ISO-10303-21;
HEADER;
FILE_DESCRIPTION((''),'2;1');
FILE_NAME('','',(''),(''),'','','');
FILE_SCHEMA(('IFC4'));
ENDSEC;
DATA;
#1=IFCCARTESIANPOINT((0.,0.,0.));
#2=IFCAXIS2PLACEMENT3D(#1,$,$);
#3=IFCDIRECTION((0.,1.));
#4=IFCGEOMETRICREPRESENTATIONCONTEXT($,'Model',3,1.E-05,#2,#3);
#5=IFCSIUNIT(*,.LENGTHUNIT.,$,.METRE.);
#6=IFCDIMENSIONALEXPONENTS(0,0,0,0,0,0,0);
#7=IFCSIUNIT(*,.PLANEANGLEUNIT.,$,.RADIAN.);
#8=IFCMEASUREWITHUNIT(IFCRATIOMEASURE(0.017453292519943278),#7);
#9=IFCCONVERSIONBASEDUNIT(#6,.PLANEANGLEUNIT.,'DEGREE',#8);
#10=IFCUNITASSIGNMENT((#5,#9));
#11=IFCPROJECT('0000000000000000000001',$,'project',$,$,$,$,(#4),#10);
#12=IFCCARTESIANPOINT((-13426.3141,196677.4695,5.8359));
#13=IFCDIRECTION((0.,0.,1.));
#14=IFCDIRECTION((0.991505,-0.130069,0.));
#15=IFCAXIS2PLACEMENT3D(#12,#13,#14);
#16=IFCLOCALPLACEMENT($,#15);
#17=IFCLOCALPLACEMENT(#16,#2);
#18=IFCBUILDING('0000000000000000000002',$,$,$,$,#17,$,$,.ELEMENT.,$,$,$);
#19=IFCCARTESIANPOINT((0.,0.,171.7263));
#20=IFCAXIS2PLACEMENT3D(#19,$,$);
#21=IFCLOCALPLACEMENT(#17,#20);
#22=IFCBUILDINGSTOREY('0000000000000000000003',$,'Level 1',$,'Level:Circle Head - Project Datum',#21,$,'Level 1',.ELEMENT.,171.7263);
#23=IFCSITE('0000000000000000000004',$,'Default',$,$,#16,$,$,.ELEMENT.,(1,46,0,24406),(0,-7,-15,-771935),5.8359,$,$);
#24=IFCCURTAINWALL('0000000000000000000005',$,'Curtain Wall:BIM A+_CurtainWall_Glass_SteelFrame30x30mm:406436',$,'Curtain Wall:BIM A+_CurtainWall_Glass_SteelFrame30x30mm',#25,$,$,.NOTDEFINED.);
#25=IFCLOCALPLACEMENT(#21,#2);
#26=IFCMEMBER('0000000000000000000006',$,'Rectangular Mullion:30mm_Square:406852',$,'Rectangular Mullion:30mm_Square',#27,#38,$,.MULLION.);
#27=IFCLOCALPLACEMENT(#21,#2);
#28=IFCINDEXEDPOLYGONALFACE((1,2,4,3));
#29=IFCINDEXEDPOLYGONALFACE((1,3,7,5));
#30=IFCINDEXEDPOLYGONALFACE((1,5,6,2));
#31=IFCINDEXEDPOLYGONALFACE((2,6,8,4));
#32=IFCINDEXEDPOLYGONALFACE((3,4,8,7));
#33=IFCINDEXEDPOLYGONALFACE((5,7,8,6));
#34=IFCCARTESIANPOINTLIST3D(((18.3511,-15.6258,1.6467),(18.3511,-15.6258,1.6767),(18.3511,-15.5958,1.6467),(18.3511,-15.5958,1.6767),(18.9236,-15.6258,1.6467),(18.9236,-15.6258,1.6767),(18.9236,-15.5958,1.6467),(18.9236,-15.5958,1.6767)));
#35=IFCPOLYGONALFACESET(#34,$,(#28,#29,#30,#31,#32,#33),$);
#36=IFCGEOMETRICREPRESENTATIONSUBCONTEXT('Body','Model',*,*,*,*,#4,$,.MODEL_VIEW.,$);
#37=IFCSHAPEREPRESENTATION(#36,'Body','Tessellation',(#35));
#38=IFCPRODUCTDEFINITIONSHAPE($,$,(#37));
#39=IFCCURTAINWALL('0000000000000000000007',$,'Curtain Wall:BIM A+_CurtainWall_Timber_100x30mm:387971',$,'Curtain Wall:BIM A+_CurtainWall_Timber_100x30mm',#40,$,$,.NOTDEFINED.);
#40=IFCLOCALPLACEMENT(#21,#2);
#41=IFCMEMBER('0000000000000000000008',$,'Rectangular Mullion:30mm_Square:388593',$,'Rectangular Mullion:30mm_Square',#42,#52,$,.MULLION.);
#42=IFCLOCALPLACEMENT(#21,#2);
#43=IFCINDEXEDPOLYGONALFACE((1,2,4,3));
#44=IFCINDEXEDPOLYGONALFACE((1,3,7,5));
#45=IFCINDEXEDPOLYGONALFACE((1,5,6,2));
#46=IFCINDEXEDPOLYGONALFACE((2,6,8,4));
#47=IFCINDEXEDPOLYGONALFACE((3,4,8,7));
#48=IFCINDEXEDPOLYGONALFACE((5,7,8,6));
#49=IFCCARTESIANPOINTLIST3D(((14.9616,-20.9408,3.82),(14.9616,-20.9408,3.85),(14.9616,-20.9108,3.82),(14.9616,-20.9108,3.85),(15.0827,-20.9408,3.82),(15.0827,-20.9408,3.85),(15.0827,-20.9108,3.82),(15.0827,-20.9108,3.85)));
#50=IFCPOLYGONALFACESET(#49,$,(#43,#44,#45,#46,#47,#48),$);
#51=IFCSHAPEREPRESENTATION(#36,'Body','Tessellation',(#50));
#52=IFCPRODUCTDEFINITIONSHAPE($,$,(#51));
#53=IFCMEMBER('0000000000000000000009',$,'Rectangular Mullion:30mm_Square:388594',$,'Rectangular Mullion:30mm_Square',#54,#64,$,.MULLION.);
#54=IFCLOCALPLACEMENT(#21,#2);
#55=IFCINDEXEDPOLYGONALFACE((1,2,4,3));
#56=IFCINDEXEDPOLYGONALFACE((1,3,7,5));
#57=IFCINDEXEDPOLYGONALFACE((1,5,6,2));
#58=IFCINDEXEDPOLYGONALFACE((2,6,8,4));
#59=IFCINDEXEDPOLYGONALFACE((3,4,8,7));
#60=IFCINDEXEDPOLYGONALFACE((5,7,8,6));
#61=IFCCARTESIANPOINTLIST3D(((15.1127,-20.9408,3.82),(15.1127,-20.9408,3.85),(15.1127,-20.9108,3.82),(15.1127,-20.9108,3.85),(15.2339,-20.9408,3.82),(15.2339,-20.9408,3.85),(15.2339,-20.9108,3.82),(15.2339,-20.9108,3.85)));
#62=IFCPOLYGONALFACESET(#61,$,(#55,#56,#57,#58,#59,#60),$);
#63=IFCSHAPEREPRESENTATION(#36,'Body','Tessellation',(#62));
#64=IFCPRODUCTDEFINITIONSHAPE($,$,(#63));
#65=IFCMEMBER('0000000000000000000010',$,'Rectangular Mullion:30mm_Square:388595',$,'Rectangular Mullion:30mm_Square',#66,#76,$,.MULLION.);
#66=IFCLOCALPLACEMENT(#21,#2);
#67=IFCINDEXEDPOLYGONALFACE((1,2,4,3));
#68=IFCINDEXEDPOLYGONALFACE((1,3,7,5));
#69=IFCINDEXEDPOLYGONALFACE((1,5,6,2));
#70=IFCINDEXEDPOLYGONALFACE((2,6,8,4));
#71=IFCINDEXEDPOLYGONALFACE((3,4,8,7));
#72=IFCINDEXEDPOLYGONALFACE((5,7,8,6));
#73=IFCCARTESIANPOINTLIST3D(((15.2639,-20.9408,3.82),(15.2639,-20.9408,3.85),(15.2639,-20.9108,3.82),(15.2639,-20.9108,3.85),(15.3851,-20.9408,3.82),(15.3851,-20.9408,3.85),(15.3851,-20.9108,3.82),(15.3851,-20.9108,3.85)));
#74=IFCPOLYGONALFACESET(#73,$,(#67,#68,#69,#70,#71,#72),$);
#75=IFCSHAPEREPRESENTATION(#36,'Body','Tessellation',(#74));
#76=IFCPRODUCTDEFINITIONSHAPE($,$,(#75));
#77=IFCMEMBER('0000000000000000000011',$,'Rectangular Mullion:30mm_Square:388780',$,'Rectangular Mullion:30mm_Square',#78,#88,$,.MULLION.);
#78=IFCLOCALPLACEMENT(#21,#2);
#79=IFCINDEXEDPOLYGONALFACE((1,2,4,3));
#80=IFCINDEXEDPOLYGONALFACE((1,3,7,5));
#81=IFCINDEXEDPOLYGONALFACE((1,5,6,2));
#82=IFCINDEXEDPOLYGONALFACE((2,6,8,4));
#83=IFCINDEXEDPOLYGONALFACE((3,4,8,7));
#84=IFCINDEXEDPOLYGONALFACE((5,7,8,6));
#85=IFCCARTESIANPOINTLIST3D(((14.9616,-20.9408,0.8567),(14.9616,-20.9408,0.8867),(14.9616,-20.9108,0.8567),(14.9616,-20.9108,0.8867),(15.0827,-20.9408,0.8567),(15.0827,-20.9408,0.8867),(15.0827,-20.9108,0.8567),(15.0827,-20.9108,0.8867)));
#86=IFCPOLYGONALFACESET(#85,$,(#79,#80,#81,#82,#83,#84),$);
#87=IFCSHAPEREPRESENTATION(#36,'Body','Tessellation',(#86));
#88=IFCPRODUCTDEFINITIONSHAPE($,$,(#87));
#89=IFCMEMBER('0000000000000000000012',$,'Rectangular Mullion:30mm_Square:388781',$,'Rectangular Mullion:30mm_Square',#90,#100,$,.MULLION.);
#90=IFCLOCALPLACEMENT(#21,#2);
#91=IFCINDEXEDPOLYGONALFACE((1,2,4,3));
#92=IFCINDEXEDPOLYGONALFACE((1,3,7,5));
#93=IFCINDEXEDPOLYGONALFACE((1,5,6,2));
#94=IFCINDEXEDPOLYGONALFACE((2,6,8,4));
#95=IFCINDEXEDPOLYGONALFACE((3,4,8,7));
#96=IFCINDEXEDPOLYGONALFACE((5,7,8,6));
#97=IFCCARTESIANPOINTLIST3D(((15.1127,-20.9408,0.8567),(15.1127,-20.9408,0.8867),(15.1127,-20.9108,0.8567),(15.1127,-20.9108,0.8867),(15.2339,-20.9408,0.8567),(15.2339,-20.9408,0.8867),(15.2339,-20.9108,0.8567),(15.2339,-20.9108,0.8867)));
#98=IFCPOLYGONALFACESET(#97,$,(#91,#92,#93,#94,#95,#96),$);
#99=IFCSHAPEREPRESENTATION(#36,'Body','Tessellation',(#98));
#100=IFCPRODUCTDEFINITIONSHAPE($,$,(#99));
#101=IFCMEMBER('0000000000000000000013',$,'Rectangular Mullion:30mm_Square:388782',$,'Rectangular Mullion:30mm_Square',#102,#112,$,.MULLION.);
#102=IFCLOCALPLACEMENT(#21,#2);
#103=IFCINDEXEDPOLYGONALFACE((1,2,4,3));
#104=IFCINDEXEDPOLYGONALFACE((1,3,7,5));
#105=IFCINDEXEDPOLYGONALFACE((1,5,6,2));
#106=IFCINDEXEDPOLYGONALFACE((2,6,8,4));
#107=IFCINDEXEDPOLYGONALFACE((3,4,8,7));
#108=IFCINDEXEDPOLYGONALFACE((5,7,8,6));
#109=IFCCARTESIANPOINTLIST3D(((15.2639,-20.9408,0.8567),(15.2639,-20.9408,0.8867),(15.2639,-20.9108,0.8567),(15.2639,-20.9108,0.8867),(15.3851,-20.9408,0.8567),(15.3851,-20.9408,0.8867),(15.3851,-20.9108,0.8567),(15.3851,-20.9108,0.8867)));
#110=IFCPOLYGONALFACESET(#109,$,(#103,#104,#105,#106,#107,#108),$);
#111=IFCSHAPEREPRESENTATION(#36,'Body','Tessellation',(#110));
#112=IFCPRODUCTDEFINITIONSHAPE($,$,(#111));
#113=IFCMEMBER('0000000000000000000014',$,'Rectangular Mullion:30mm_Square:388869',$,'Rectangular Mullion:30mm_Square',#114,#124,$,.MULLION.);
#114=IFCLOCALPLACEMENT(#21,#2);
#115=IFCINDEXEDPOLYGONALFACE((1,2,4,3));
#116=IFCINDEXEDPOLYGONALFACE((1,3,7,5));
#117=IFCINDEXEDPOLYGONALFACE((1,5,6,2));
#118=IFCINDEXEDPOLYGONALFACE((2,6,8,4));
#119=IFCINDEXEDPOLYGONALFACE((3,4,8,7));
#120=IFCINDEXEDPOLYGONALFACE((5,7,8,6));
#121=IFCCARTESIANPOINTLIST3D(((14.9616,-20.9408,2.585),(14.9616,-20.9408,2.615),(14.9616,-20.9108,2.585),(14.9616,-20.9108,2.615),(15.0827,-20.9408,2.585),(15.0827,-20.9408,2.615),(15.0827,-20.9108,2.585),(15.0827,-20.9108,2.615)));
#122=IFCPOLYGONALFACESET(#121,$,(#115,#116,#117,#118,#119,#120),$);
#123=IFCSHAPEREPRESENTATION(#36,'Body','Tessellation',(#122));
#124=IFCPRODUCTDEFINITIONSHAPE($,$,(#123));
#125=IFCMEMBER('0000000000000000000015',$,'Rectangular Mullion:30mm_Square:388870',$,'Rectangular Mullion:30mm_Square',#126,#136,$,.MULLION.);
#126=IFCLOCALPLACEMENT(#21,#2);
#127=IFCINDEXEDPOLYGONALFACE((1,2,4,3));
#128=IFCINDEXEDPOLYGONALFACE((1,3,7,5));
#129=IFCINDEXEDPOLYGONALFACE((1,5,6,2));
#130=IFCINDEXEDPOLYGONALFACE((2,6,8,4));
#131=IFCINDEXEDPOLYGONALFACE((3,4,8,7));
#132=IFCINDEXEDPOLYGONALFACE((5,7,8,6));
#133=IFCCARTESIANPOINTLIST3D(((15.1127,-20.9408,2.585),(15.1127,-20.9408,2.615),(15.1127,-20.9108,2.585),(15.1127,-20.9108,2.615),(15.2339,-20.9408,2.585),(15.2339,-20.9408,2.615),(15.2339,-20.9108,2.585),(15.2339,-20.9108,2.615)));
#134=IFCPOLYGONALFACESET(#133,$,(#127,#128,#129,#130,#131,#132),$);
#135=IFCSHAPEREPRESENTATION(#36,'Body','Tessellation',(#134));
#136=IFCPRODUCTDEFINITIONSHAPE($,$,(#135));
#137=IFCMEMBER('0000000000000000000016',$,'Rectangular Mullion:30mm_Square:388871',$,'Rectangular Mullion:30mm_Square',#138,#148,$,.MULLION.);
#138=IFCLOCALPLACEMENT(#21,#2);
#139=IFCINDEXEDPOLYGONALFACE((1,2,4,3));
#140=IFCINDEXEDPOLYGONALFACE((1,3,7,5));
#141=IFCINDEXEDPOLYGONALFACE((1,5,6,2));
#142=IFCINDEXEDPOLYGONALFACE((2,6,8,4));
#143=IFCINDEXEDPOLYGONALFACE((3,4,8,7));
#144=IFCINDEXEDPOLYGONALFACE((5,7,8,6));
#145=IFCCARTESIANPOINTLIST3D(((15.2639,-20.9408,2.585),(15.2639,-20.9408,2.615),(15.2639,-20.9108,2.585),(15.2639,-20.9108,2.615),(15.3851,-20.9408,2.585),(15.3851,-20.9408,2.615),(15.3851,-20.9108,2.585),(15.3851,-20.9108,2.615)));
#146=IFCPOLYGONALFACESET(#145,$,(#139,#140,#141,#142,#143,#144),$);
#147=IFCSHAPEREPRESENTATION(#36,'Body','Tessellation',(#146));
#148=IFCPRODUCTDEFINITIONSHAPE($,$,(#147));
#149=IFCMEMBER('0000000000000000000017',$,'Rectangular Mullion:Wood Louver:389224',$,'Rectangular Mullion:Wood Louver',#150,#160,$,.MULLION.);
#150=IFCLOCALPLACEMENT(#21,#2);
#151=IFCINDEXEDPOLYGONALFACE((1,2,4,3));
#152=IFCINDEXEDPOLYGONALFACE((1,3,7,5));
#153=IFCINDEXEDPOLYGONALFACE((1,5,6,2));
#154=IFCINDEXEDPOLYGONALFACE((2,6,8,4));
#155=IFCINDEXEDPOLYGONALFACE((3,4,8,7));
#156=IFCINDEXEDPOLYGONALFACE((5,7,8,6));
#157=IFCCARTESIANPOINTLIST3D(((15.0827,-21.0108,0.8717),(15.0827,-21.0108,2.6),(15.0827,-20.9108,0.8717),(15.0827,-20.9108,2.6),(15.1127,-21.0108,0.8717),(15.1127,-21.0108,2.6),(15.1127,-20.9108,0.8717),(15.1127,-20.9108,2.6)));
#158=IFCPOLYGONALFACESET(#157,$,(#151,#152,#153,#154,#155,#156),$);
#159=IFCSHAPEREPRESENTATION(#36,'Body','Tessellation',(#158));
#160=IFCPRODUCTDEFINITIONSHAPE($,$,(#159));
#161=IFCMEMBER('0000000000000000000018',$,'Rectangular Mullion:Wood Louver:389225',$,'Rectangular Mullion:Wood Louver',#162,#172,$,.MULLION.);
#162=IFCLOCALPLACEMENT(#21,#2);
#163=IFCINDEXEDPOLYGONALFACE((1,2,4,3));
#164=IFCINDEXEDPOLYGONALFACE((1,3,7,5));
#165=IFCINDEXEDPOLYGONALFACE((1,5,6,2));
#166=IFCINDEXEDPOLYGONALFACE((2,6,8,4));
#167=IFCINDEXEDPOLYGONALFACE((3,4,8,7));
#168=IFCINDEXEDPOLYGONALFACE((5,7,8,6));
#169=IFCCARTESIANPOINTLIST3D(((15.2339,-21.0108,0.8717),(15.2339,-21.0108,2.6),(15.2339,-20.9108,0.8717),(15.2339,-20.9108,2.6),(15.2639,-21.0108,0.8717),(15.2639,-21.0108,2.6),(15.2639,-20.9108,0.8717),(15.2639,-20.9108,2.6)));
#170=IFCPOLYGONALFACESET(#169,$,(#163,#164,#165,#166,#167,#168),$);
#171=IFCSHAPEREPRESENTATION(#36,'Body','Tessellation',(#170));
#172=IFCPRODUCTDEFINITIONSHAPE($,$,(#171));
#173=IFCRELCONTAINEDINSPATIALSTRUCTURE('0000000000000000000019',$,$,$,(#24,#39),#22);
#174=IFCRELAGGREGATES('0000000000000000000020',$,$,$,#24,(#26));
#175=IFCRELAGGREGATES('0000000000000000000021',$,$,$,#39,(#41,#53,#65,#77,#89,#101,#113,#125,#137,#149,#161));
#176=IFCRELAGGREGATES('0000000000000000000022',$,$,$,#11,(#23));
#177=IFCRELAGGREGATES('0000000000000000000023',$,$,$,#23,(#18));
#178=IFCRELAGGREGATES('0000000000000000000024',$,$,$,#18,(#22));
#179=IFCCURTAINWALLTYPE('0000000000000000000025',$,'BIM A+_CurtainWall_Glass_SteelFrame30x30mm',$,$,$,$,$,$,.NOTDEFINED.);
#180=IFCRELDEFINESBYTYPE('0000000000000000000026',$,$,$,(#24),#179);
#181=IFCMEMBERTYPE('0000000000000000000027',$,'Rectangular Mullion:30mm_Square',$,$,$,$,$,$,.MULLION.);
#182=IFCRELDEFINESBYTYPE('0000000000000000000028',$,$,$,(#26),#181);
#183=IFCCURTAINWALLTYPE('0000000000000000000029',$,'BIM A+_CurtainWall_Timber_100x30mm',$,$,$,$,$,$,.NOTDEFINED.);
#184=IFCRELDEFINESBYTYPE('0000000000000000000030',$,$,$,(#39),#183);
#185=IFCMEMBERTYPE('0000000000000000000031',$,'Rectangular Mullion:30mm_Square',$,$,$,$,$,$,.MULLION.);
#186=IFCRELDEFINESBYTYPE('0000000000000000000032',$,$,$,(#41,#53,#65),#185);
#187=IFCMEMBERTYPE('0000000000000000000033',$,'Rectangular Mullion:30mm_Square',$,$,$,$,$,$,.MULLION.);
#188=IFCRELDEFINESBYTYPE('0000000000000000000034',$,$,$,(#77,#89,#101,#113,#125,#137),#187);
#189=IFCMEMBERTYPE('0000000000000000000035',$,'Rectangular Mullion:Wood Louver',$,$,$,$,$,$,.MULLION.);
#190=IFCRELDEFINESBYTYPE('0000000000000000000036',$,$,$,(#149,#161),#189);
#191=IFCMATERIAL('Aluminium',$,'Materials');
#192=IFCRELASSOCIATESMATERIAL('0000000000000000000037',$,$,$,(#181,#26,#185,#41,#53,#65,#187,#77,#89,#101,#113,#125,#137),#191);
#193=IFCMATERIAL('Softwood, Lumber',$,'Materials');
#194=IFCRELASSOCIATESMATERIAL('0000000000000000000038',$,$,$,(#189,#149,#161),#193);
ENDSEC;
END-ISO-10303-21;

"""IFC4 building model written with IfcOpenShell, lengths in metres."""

from ifc_helpers import new_model, entity, si_unit, converted_unit, direction, frame, origin, place, context, subcontext, project, spatial, indexed_curve, outline, extrude, source, transform, mapped, material, type_object, type_shapes, element, aggregate, save


model = new_model("IFC4")

# Units and contexts
model_context = context("Model", 3, precision=1e-05, world=origin(), true_north=direction((0.0, 1.0)))
body_context = subcontext(model_context, "Body", "Model", "MODEL_VIEW")
ifc_project = project(units=[si_unit("LENGTHUNIT", "METRE"), converted_unit("PLANEANGLEUNIT", "DEGREE", entity("IfcRatioMeasure", 0.017453292519943278), si_unit("PLANEANGLEUNIT", "RADIAN"), dimensions=[0, 0, 0, 0, 0, 0, 0])], contexts=[model_context])

# Site, building, storey
site_placement = place(None, frame((-13426.3141, 196677.4695, 5.8359), z_axis=(0.0, 0.0, 1.0), x_axis=(0.991505, -0.130069, 0.0)))
site = spatial("IfcSite", under=ifc_project, at=site_placement, Name="Default", CompositionType="ELEMENT", RefLatitude=(1, 46, 0, 24406), RefLongitude=(0, -7, -15, -771935), RefElevation=5.8359)
building_placement = place(site_placement, origin())
building = spatial("IfcBuilding", under=site, at=building_placement, CompositionType="ELEMENT")
storey_placement = place(building_placement, frame((0.0, 0.0, 171.7263)))
storey = spatial("IfcBuildingStorey", under=building, at=storey_placement, Name="Level 1", ObjectType="Level:Circle Head - Project Datum", LongName="Level 1", CompositionType="ELEMENT", Elevation=171.7263)

# Shared definitions
curtain_wall_type_1 = type_object("IfcCurtainWallType", Name="BIM A+_CurtainWall_Glass_SteelFrame30x30mm", PredefinedType="NOTDEFINED")
ifc_material_1 = material(Name="Aluminium", Category="Materials")

# Curtain wall
curtain_wall_1_placement = place(storey_placement, frame((0.0, 0.0, -171.7263)))
curtain_wall_1 = element("IfcCurtainWall", 1, at=curtain_wall_1_placement, inside=storey, type_object=curtain_wall_type_1, Name="Curtain Wall:BIM A+_CurtainWall_Glass_SteelFrame30x30mm:406436", ObjectType="Curtain Wall:BIM A+_CurtainWall_Glass_SteelFrame30x30mm", PredefinedType="NOTDEFINED")

# Member
member_type_1 = type_object("IfcMemberType", Name="Rectangular Mullion:30mm_Square", PredefinedType="MULLION", material=ifc_material_1)
shared_shape_1 = source(origin(), body_context, "Body", "SweptSolid", [
    extrude(outline(indexed_curve([(-0.015, -0.015), (0.015, -0.015), (0.015, 0.015), (-0.015, 0.015), (-0.015, -0.015)], self_intersect=False)), frame((0.0, 0.0, -0.5725), z_axis=(0.0, 0.0, 1.0), x_axis=(0.0, -1.0, 0.0)), (0.0, 0.0, 1.0), 0.5725),
])
type_shapes(member_type_1, [shared_shape_1])
member_1_placement = place(curtain_wall_1_placement, frame((18.9236, -15.6108, 173.3879), z_axis=(1.0, 0.0, 0.0), x_axis=(0.0, 0.0, 1.0)))
member_1 = element("IfcMember", 2, at=member_1_placement, type_object=member_type_1, material=ifc_material_1, Name="Rectangular Mullion:30mm_Square:406852", ObjectType="Rectangular Mullion:30mm_Square", PredefinedType="MULLION", context=body_context, shape_type="MappedRepresentation", body=[
    mapped(shared_shape_1, transform((0.0, 0.0, 0.0), scale=1.0)),
])

# Curtain wall, members
curtain_wall_type_2 = type_object("IfcCurtainWallType", Name="BIM A+_CurtainWall_Timber_100x30mm", PredefinedType="NOTDEFINED")
curtain_wall_2_placement = place(storey_placement, frame((0.0, 0.0, -171.7263)))
curtain_wall_2 = element("IfcCurtainWall", 3, at=curtain_wall_2_placement, inside=storey, type_object=curtain_wall_type_2, Name="Curtain Wall:BIM A+_CurtainWall_Timber_100x30mm:387971", ObjectType="Curtain Wall:BIM A+_CurtainWall_Timber_100x30mm", PredefinedType="NOTDEFINED")
member_type_2 = type_object("IfcMemberType", Name="Rectangular Mullion:30mm_Square", PredefinedType="MULLION", material=ifc_material_1)
shared_shape_2 = source(origin(), body_context, "Body", "SweptSolid", [
    extrude(outline(indexed_curve([(-0.015, -0.015), (0.015, -0.015), (0.015, 0.015), (-0.015, 0.015), (-0.015, -0.015)], self_intersect=False)), frame((-0.015, 0.0, -0.1212), z_axis=(0.0, 0.0, 1.0), x_axis=(0.0, -1.0, 0.0)), (0.0, 0.0, 1.0), 0.1212),
])
type_shapes(member_type_2, [shared_shape_2])
member_2_placement = place(curtain_wall_2_placement, frame((15.0827, -20.9258, 175.5763), z_axis=(1.0, 0.0, 0.0), x_axis=(0.0, 0.0, 1.0)))
member_2 = element("IfcMember", 4, at=member_2_placement, type_object=member_type_2, material=ifc_material_1, Name="Rectangular Mullion:30mm_Square:388593", ObjectType="Rectangular Mullion:30mm_Square", PredefinedType="MULLION", context=body_context, shape_type="MappedRepresentation", body=[
    mapped(shared_shape_2, transform((0.0, 0.0, 0.0), scale=1.0)),
])
member_3_placement = place(curtain_wall_2_placement, frame((15.2339, -20.9258, 175.5763), z_axis=(1.0, 0.0, 0.0), x_axis=(0.0, 0.0, 1.0)))
member_3 = element("IfcMember", 5, at=member_3_placement, type_object=member_type_2, material=ifc_material_1, Name="Rectangular Mullion:30mm_Square:388594", ObjectType="Rectangular Mullion:30mm_Square", PredefinedType="MULLION", context=body_context, shape_type="MappedRepresentation", body=[
    mapped(shared_shape_2, transform((0.0, 0.0, 0.0), scale=1.0)),
])
member_4_placement = place(curtain_wall_2_placement, frame((15.3851, -20.9258, 175.5763), z_axis=(1.0, 0.0, 0.0), x_axis=(0.0, 0.0, 1.0)))
member_4 = element("IfcMember", 6, at=member_4_placement, type_object=member_type_2, material=ifc_material_1, Name="Rectangular Mullion:30mm_Square:388595", ObjectType="Rectangular Mullion:30mm_Square", PredefinedType="MULLION", context=body_context, shape_type="MappedRepresentation", body=[
    mapped(shared_shape_2, transform((0.0, 0.0, 0.0), scale=1.0)),
])
member_type_3 = type_object("IfcMemberType", Name="Rectangular Mullion:30mm_Square", PredefinedType="MULLION", material=ifc_material_1)
shared_shape_3 = source(origin(), body_context, "Body", "SweptSolid", [
    extrude(outline(indexed_curve([(-0.015, -0.015), (0.015, -0.015), (0.015, 0.015), (-0.015, 0.015), (-0.015, -0.015)], self_intersect=False)), frame((0.0, 0.0, -0.1212), z_axis=(0.0, 0.0, 1.0), x_axis=(0.0, -1.0, 0.0)), (0.0, 0.0, 1.0), 0.1212),
])
type_shapes(member_type_3, [shared_shape_3])
member_5_placement = place(curtain_wall_2_placement, frame((15.0827, -20.9258, 172.598), z_axis=(1.0, 0.0, 0.0), x_axis=(0.0, 0.0, 1.0)))
member_5 = element("IfcMember", 7, at=member_5_placement, type_object=member_type_3, material=ifc_material_1, Name="Rectangular Mullion:30mm_Square:388780", ObjectType="Rectangular Mullion:30mm_Square", PredefinedType="MULLION", context=body_context, shape_type="MappedRepresentation", body=[
    mapped(shared_shape_3, transform((0.0, 0.0, 0.0), scale=1.0)),
])
member_6_placement = place(curtain_wall_2_placement, frame((15.2339, -20.9258, 172.598), z_axis=(1.0, 0.0, 0.0), x_axis=(0.0, 0.0, 1.0)))
member_6 = element("IfcMember", 8, at=member_6_placement, type_object=member_type_3, material=ifc_material_1, Name="Rectangular Mullion:30mm_Square:388781", ObjectType="Rectangular Mullion:30mm_Square", PredefinedType="MULLION", context=body_context, shape_type="MappedRepresentation", body=[
    mapped(shared_shape_3, transform((0.0, 0.0, 0.0), scale=1.0)),
])
member_7_placement = place(curtain_wall_2_placement, frame((15.3851, -20.9258, 172.598), z_axis=(1.0, 0.0, 0.0), x_axis=(0.0, 0.0, 1.0)))
member_7 = element("IfcMember", 9, at=member_7_placement, type_object=member_type_3, material=ifc_material_1, Name="Rectangular Mullion:30mm_Square:388782", ObjectType="Rectangular Mullion:30mm_Square", PredefinedType="MULLION", context=body_context, shape_type="MappedRepresentation", body=[
    mapped(shared_shape_3, transform((0.0, 0.0, 0.0), scale=1.0)),
])
member_8_placement = place(curtain_wall_2_placement, frame((15.0827, -20.9258, 174.3263), z_axis=(1.0, 0.0, 0.0), x_axis=(0.0, 0.0, 1.0)))
member_8 = element("IfcMember", 10, at=member_8_placement, type_object=member_type_3, material=ifc_material_1, Name="Rectangular Mullion:30mm_Square:388869", ObjectType="Rectangular Mullion:30mm_Square", PredefinedType="MULLION", context=body_context, shape_type="MappedRepresentation", body=[
    mapped(shared_shape_3, transform((0.0, 0.0, 0.0), scale=1.0)),
])
member_9_placement = place(curtain_wall_2_placement, frame((15.2339, -20.9258, 174.3263), z_axis=(1.0, 0.0, 0.0), x_axis=(0.0, 0.0, 1.0)))
member_9 = element("IfcMember", 11, at=member_9_placement, type_object=member_type_3, material=ifc_material_1, Name="Rectangular Mullion:30mm_Square:388870", ObjectType="Rectangular Mullion:30mm_Square", PredefinedType="MULLION", context=body_context, shape_type="MappedRepresentation", body=[
    mapped(shared_shape_3, transform((0.0, 0.0, 0.0), scale=1.0)),
])
member_10_placement = place(curtain_wall_2_placement, frame((15.3851, -20.9258, 174.3263), z_axis=(1.0, 0.0, 0.0), x_axis=(0.0, 0.0, 1.0)))
member_10 = element("IfcMember", 12, at=member_10_placement, type_object=member_type_3, material=ifc_material_1, Name="Rectangular Mullion:30mm_Square:388871", ObjectType="Rectangular Mullion:30mm_Square", PredefinedType="MULLION", context=body_context, shape_type="MappedRepresentation", body=[
    mapped(shared_shape_3, transform((0.0, 0.0, 0.0), scale=1.0)),
])
ifc_material_2 = material(Name="Softwood, Lumber", Category="Materials")
member_type_4 = type_object("IfcMemberType", Name="Rectangular Mullion:Wood Louver", PredefinedType="MULLION", material=ifc_material_2)
shared_shape_4 = source(origin(), body_context, "Body", "SweptSolid", [
    extrude(outline(indexed_curve([(-0.05, -0.015), (0.05, -0.015), (0.05, 0.015), (-0.05, 0.015), (-0.05, -0.015)], self_intersect=False)), frame((0.0, 0.035, -1.7283), z_axis=(0.0, 0.0, 1.0), x_axis=(0.0, -1.0, 0.0)), (0.0, 0.0, 1.0), 1.7283),
])
type_shapes(member_type_4, [shared_shape_4])
member_11_placement = place(curtain_wall_2_placement, frame((15.0977, -20.9258, 172.598), z_axis=(0.0, 0.0, -1.0), x_axis=(1.0, 0.0, 0.0)))
member_11 = element("IfcMember", 13, at=member_11_placement, type_object=member_type_4, material=ifc_material_2, Name="Rectangular Mullion:Wood Louver:389224", ObjectType="Rectangular Mullion:Wood Louver", PredefinedType="MULLION", context=body_context, shape_type="MappedRepresentation", body=[
    mapped(shared_shape_4, transform((0.0, 0.0, 0.0), scale=1.0)),
])
member_12_placement = place(curtain_wall_2_placement, frame((15.2489, -20.9258, 172.598), z_axis=(0.0, 0.0, -1.0), x_axis=(1.0, 0.0, 0.0)))
member_12 = element("IfcMember", 14, at=member_12_placement, type_object=member_type_4, material=ifc_material_2, Name="Rectangular Mullion:Wood Louver:389225", ObjectType="Rectangular Mullion:Wood Louver", PredefinedType="MULLION", context=body_context, shape_type="MappedRepresentation", body=[
    mapped(shared_shape_4, transform((0.0, 0.0, 0.0), scale=1.0)),
])

aggregate(curtain_wall_1, [member_1])
aggregate(curtain_wall_2, [member_2, member_3, member_4, member_5, member_6, member_7, member_8, member_9, member_10, member_11, member_12])

save(model, "model.ifc")
